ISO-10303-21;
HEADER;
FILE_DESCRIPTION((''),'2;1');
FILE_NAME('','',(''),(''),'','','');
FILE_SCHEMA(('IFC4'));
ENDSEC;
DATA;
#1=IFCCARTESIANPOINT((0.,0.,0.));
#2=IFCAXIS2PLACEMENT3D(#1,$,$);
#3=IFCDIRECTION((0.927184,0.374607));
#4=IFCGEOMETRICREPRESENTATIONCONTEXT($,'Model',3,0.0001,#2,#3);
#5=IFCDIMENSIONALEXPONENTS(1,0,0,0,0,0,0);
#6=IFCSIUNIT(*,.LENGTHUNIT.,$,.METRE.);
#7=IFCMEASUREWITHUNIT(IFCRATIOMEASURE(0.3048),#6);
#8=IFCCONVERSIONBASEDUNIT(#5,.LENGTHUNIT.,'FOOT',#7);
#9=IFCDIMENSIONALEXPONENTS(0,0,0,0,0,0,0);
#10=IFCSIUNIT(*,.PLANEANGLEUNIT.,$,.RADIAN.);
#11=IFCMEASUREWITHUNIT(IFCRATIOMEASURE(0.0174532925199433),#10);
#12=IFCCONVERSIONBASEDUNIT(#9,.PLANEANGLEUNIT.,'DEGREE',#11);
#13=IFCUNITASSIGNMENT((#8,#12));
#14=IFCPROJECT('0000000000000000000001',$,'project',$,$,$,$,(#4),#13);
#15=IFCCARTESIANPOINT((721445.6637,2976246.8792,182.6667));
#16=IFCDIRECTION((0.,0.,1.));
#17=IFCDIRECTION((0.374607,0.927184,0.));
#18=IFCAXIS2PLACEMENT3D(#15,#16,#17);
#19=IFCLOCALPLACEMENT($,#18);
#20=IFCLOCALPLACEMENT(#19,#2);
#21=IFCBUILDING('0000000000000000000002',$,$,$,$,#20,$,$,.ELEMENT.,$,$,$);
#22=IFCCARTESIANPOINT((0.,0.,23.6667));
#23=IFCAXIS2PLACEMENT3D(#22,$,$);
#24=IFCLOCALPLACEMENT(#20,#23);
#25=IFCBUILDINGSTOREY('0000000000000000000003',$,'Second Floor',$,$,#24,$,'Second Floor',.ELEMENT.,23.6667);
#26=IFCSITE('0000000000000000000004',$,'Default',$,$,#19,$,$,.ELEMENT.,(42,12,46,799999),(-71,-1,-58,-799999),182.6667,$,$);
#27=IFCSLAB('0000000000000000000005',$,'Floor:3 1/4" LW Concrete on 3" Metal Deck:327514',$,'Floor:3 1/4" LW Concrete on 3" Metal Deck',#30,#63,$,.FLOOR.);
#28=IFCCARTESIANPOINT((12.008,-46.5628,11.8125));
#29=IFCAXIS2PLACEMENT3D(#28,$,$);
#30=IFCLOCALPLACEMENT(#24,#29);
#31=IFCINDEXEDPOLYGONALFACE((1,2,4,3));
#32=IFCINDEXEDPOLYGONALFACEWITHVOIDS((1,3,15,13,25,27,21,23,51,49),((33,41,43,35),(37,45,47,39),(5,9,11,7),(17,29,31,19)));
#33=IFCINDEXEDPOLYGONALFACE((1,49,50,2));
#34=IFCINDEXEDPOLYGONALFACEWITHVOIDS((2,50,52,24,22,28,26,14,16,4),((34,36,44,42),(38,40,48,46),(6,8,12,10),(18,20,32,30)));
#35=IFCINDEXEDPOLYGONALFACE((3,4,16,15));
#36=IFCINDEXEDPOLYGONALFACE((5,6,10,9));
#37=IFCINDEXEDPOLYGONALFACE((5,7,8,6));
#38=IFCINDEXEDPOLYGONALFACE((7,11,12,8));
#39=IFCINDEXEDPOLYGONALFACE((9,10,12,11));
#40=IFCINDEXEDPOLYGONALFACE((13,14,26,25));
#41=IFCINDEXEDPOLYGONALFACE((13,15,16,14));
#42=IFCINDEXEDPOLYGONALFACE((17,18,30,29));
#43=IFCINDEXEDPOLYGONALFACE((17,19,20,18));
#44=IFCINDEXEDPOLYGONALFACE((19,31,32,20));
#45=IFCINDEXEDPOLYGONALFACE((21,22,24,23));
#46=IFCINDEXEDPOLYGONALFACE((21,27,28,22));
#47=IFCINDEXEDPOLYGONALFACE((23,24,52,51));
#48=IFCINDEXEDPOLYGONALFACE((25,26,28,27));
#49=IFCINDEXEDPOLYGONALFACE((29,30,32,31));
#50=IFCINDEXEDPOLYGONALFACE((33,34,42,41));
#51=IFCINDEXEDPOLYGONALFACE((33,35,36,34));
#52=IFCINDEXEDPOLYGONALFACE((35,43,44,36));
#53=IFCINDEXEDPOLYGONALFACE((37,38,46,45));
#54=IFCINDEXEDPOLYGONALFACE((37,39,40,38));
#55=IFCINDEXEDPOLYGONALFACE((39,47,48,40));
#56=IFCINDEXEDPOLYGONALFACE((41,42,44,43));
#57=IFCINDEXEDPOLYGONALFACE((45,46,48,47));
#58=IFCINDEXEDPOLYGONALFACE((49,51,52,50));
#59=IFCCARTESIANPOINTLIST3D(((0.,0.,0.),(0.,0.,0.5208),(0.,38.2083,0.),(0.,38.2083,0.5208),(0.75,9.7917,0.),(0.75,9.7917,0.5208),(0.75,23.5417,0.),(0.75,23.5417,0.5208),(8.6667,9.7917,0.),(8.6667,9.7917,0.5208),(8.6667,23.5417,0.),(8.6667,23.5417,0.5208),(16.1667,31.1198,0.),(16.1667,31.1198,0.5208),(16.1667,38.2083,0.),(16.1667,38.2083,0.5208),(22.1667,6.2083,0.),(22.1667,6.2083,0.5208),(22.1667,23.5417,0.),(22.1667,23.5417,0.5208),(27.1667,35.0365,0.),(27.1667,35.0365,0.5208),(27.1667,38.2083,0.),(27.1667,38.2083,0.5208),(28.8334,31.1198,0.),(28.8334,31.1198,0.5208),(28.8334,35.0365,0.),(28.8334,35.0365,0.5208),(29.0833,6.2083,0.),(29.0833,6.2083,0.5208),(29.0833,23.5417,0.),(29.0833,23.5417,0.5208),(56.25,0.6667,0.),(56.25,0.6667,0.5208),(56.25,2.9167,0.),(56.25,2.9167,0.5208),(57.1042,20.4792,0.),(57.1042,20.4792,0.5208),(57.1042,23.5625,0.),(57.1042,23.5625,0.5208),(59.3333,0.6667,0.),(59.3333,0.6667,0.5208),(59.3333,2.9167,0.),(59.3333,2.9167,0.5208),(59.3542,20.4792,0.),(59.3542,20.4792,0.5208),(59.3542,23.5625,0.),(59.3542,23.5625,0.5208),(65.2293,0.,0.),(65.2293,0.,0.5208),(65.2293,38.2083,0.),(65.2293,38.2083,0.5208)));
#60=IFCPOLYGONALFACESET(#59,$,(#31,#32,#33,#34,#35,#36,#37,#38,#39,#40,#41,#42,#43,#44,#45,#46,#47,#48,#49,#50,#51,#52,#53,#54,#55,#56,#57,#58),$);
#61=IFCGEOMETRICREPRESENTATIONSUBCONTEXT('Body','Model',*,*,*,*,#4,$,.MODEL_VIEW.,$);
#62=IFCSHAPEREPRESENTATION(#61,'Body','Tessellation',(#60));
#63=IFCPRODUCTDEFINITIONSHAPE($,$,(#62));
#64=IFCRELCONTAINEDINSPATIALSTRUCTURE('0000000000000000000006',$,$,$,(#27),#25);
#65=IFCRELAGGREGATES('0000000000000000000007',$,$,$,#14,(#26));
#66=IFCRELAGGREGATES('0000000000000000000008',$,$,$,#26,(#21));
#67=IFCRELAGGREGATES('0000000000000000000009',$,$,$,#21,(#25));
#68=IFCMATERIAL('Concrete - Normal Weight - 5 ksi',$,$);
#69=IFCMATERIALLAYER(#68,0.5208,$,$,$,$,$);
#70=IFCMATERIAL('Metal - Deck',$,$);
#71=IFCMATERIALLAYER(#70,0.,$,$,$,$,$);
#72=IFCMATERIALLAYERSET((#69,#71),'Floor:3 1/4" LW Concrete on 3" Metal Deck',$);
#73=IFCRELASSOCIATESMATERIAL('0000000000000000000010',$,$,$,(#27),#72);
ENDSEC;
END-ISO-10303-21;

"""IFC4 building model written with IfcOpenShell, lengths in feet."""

from ifc_helpers import new_model, entity, si_unit, converted_unit, direction, frame, origin, origin_2d_with_axis, place, context, subcontext, project, spatial, polyline, rectangle, outline, extrude, material, layer, layer_set, layer_usage, element, save


model = new_model("IFC4")

# Units and contexts
model_context = context("Model", 3, precision=0.0001, world=origin(), true_north=direction((0.927184, 0.374607)))
body_context = subcontext(model_context, "Body", "Model", "MODEL_VIEW")
ifc_project = project(units=[converted_unit("LENGTHUNIT", "FOOT", entity("IfcRatioMeasure", 0.3048), si_unit("LENGTHUNIT", "METRE"), dimensions=[1, 0, 0, 0, 0, 0, 0]), converted_unit("PLANEANGLEUNIT", "DEGREE", entity("IfcRatioMeasure", 0.0174532925199433), si_unit("PLANEANGLEUNIT", "RADIAN"), dimensions=[0, 0, 0, 0, 0, 0, 0])], contexts=[model_context])

# Site, building, storey
site_placement = place(None, frame((721445.6637, 2976246.8792, 182.6667), z_axis=(0.0, 0.0, 1.0), x_axis=(0.374607, 0.927184, 0.0)))
site = spatial("IfcSite", under=ifc_project, at=site_placement, Name="Default", CompositionType="ELEMENT", RefLatitude=(42, 12, 46, 799999), RefLongitude=(-71, -1, -58, -799999), RefElevation=182.6667)
building_placement = place(site_placement, origin())
building = spatial("IfcBuilding", under=site, at=building_placement, CompositionType="ELEMENT")
storey_placement = place(building_placement, frame((0.0, 0.0, 23.6667)))
storey = spatial("IfcBuildingStorey", under=building, at=storey_placement, Name="Second Floor", LongName="Second Floor", CompositionType="ELEMENT", Elevation=23.6667)

# Slab, openings
ifc_material_1 = material(Name="Concrete - Normal Weight - 5 ksi")
ifc_layer_1 = layer(ifc_material_1, 0.5208)
ifc_material_2 = material(Name="Metal - Deck")
ifc_layer_2 = layer(ifc_material_2, 0.0)
ifc_layer_set = layer_set([ifc_layer_1, ifc_layer_2], Name="Floor:3 1/4\" LW Concrete on 3\" Metal Deck")
ifc_layer_usage = layer_usage(ifc_layer_set, "AXIS3", "POSITIVE", 0.0)
slab_placement = place(storey_placement, frame((12.008, -46.5628, 11.8125)))
slab = element("IfcSlab", 1, at=slab_placement, inside=storey, material=ifc_layer_usage, Name="Floor:3 1/4\" LW Concrete on 3\" Metal Deck:327514", ObjectType="Floor:3 1/4\" LW Concrete on 3\" Metal Deck", PredefinedType="FLOOR", context=body_context, shape_type="SweptSolid", body=[
    extrude(outline(polyline([(32.6146, 19.1042), (16.4479, 19.1042), (16.4479, 12.0156), (3.7812, 12.0156), (3.7812, 15.9323), (5.4479, 15.9323), (5.4479, 19.1042), (3.7812, 19.1042), (-32.6146, 19.1042), (-32.6146, -19.1042), (32.6146, -19.1042), (32.6146, 19.1042)])), frame((32.6146, 19.1042, 0.5208), z_axis=(0.0, 0.0, -1.0), x_axis=(-1.0, 0.0, 0.0)), (0.0, 0.0, 1.0), 0.5208),
])
opening_1_placement = place(slab_placement, frame((4.7083, 16.6667, 0.5208)))
element("IfcOpeningElement", 2, at=opening_1_placement, cuts=slab, ObjectType="Opening", context=body_context, shape_type="SweptSolid", body=[
    extrude(rectangle(XDim=7.9167, YDim=13.75, at=origin_2d_with_axis()), frame((0.0, 0.0, 0.0), z_axis=(0.0, 0.0, -1.0), x_axis=(1.0, 0.0, 0.0)), (0.0, 0.0, 1.0), 0.5208),
])
opening_2_placement = place(slab_placement, frame((25.625, 14.875, 0.5208)))
element("IfcOpeningElement", 3, at=opening_2_placement, cuts=slab, ObjectType="Opening", context=body_context, shape_type="SweptSolid", body=[
    extrude(rectangle(XDim=6.9167, YDim=17.3333, at=origin_2d_with_axis()), frame((0.0, 0.0, 0.0), z_axis=(0.0, 0.0, -1.0), x_axis=(1.0, 0.0, 0.0)), (0.0, 0.0, 1.0), 0.5208),
])
opening_3_placement = place(slab_placement, frame((58.2292, 22.0208, 0.5208)))
element("IfcOpeningElement", 4, at=opening_3_placement, cuts=slab, ObjectType="Opening", context=body_context, shape_type="SweptSolid", body=[
    extrude(rectangle(XDim=2.25, YDim=3.0833, at=origin_2d_with_axis()), frame((0.0, 0.0, 0.0), z_axis=(0.0, 0.0, -1.0), x_axis=(1.0, 0.0, 0.0)), (0.0, 0.0, 1.0), 0.5208),
])
opening_4_placement = place(slab_placement, frame((57.7917, 1.7917, 0.5208)))
element("IfcOpeningElement", 5, at=opening_4_placement, cuts=slab, ObjectType="Opening", context=body_context, shape_type="SweptSolid", body=[
    extrude(rectangle(XDim=3.0833, YDim=2.25, at=origin_2d_with_axis()), frame((0.0, 0.0, 0.0), z_axis=(0.0, 0.0, -1.0), x_axis=(1.0, 0.0, 0.0)), (0.0, 0.0, 1.0), 0.5208),
])

save(model, "model.ifc")
